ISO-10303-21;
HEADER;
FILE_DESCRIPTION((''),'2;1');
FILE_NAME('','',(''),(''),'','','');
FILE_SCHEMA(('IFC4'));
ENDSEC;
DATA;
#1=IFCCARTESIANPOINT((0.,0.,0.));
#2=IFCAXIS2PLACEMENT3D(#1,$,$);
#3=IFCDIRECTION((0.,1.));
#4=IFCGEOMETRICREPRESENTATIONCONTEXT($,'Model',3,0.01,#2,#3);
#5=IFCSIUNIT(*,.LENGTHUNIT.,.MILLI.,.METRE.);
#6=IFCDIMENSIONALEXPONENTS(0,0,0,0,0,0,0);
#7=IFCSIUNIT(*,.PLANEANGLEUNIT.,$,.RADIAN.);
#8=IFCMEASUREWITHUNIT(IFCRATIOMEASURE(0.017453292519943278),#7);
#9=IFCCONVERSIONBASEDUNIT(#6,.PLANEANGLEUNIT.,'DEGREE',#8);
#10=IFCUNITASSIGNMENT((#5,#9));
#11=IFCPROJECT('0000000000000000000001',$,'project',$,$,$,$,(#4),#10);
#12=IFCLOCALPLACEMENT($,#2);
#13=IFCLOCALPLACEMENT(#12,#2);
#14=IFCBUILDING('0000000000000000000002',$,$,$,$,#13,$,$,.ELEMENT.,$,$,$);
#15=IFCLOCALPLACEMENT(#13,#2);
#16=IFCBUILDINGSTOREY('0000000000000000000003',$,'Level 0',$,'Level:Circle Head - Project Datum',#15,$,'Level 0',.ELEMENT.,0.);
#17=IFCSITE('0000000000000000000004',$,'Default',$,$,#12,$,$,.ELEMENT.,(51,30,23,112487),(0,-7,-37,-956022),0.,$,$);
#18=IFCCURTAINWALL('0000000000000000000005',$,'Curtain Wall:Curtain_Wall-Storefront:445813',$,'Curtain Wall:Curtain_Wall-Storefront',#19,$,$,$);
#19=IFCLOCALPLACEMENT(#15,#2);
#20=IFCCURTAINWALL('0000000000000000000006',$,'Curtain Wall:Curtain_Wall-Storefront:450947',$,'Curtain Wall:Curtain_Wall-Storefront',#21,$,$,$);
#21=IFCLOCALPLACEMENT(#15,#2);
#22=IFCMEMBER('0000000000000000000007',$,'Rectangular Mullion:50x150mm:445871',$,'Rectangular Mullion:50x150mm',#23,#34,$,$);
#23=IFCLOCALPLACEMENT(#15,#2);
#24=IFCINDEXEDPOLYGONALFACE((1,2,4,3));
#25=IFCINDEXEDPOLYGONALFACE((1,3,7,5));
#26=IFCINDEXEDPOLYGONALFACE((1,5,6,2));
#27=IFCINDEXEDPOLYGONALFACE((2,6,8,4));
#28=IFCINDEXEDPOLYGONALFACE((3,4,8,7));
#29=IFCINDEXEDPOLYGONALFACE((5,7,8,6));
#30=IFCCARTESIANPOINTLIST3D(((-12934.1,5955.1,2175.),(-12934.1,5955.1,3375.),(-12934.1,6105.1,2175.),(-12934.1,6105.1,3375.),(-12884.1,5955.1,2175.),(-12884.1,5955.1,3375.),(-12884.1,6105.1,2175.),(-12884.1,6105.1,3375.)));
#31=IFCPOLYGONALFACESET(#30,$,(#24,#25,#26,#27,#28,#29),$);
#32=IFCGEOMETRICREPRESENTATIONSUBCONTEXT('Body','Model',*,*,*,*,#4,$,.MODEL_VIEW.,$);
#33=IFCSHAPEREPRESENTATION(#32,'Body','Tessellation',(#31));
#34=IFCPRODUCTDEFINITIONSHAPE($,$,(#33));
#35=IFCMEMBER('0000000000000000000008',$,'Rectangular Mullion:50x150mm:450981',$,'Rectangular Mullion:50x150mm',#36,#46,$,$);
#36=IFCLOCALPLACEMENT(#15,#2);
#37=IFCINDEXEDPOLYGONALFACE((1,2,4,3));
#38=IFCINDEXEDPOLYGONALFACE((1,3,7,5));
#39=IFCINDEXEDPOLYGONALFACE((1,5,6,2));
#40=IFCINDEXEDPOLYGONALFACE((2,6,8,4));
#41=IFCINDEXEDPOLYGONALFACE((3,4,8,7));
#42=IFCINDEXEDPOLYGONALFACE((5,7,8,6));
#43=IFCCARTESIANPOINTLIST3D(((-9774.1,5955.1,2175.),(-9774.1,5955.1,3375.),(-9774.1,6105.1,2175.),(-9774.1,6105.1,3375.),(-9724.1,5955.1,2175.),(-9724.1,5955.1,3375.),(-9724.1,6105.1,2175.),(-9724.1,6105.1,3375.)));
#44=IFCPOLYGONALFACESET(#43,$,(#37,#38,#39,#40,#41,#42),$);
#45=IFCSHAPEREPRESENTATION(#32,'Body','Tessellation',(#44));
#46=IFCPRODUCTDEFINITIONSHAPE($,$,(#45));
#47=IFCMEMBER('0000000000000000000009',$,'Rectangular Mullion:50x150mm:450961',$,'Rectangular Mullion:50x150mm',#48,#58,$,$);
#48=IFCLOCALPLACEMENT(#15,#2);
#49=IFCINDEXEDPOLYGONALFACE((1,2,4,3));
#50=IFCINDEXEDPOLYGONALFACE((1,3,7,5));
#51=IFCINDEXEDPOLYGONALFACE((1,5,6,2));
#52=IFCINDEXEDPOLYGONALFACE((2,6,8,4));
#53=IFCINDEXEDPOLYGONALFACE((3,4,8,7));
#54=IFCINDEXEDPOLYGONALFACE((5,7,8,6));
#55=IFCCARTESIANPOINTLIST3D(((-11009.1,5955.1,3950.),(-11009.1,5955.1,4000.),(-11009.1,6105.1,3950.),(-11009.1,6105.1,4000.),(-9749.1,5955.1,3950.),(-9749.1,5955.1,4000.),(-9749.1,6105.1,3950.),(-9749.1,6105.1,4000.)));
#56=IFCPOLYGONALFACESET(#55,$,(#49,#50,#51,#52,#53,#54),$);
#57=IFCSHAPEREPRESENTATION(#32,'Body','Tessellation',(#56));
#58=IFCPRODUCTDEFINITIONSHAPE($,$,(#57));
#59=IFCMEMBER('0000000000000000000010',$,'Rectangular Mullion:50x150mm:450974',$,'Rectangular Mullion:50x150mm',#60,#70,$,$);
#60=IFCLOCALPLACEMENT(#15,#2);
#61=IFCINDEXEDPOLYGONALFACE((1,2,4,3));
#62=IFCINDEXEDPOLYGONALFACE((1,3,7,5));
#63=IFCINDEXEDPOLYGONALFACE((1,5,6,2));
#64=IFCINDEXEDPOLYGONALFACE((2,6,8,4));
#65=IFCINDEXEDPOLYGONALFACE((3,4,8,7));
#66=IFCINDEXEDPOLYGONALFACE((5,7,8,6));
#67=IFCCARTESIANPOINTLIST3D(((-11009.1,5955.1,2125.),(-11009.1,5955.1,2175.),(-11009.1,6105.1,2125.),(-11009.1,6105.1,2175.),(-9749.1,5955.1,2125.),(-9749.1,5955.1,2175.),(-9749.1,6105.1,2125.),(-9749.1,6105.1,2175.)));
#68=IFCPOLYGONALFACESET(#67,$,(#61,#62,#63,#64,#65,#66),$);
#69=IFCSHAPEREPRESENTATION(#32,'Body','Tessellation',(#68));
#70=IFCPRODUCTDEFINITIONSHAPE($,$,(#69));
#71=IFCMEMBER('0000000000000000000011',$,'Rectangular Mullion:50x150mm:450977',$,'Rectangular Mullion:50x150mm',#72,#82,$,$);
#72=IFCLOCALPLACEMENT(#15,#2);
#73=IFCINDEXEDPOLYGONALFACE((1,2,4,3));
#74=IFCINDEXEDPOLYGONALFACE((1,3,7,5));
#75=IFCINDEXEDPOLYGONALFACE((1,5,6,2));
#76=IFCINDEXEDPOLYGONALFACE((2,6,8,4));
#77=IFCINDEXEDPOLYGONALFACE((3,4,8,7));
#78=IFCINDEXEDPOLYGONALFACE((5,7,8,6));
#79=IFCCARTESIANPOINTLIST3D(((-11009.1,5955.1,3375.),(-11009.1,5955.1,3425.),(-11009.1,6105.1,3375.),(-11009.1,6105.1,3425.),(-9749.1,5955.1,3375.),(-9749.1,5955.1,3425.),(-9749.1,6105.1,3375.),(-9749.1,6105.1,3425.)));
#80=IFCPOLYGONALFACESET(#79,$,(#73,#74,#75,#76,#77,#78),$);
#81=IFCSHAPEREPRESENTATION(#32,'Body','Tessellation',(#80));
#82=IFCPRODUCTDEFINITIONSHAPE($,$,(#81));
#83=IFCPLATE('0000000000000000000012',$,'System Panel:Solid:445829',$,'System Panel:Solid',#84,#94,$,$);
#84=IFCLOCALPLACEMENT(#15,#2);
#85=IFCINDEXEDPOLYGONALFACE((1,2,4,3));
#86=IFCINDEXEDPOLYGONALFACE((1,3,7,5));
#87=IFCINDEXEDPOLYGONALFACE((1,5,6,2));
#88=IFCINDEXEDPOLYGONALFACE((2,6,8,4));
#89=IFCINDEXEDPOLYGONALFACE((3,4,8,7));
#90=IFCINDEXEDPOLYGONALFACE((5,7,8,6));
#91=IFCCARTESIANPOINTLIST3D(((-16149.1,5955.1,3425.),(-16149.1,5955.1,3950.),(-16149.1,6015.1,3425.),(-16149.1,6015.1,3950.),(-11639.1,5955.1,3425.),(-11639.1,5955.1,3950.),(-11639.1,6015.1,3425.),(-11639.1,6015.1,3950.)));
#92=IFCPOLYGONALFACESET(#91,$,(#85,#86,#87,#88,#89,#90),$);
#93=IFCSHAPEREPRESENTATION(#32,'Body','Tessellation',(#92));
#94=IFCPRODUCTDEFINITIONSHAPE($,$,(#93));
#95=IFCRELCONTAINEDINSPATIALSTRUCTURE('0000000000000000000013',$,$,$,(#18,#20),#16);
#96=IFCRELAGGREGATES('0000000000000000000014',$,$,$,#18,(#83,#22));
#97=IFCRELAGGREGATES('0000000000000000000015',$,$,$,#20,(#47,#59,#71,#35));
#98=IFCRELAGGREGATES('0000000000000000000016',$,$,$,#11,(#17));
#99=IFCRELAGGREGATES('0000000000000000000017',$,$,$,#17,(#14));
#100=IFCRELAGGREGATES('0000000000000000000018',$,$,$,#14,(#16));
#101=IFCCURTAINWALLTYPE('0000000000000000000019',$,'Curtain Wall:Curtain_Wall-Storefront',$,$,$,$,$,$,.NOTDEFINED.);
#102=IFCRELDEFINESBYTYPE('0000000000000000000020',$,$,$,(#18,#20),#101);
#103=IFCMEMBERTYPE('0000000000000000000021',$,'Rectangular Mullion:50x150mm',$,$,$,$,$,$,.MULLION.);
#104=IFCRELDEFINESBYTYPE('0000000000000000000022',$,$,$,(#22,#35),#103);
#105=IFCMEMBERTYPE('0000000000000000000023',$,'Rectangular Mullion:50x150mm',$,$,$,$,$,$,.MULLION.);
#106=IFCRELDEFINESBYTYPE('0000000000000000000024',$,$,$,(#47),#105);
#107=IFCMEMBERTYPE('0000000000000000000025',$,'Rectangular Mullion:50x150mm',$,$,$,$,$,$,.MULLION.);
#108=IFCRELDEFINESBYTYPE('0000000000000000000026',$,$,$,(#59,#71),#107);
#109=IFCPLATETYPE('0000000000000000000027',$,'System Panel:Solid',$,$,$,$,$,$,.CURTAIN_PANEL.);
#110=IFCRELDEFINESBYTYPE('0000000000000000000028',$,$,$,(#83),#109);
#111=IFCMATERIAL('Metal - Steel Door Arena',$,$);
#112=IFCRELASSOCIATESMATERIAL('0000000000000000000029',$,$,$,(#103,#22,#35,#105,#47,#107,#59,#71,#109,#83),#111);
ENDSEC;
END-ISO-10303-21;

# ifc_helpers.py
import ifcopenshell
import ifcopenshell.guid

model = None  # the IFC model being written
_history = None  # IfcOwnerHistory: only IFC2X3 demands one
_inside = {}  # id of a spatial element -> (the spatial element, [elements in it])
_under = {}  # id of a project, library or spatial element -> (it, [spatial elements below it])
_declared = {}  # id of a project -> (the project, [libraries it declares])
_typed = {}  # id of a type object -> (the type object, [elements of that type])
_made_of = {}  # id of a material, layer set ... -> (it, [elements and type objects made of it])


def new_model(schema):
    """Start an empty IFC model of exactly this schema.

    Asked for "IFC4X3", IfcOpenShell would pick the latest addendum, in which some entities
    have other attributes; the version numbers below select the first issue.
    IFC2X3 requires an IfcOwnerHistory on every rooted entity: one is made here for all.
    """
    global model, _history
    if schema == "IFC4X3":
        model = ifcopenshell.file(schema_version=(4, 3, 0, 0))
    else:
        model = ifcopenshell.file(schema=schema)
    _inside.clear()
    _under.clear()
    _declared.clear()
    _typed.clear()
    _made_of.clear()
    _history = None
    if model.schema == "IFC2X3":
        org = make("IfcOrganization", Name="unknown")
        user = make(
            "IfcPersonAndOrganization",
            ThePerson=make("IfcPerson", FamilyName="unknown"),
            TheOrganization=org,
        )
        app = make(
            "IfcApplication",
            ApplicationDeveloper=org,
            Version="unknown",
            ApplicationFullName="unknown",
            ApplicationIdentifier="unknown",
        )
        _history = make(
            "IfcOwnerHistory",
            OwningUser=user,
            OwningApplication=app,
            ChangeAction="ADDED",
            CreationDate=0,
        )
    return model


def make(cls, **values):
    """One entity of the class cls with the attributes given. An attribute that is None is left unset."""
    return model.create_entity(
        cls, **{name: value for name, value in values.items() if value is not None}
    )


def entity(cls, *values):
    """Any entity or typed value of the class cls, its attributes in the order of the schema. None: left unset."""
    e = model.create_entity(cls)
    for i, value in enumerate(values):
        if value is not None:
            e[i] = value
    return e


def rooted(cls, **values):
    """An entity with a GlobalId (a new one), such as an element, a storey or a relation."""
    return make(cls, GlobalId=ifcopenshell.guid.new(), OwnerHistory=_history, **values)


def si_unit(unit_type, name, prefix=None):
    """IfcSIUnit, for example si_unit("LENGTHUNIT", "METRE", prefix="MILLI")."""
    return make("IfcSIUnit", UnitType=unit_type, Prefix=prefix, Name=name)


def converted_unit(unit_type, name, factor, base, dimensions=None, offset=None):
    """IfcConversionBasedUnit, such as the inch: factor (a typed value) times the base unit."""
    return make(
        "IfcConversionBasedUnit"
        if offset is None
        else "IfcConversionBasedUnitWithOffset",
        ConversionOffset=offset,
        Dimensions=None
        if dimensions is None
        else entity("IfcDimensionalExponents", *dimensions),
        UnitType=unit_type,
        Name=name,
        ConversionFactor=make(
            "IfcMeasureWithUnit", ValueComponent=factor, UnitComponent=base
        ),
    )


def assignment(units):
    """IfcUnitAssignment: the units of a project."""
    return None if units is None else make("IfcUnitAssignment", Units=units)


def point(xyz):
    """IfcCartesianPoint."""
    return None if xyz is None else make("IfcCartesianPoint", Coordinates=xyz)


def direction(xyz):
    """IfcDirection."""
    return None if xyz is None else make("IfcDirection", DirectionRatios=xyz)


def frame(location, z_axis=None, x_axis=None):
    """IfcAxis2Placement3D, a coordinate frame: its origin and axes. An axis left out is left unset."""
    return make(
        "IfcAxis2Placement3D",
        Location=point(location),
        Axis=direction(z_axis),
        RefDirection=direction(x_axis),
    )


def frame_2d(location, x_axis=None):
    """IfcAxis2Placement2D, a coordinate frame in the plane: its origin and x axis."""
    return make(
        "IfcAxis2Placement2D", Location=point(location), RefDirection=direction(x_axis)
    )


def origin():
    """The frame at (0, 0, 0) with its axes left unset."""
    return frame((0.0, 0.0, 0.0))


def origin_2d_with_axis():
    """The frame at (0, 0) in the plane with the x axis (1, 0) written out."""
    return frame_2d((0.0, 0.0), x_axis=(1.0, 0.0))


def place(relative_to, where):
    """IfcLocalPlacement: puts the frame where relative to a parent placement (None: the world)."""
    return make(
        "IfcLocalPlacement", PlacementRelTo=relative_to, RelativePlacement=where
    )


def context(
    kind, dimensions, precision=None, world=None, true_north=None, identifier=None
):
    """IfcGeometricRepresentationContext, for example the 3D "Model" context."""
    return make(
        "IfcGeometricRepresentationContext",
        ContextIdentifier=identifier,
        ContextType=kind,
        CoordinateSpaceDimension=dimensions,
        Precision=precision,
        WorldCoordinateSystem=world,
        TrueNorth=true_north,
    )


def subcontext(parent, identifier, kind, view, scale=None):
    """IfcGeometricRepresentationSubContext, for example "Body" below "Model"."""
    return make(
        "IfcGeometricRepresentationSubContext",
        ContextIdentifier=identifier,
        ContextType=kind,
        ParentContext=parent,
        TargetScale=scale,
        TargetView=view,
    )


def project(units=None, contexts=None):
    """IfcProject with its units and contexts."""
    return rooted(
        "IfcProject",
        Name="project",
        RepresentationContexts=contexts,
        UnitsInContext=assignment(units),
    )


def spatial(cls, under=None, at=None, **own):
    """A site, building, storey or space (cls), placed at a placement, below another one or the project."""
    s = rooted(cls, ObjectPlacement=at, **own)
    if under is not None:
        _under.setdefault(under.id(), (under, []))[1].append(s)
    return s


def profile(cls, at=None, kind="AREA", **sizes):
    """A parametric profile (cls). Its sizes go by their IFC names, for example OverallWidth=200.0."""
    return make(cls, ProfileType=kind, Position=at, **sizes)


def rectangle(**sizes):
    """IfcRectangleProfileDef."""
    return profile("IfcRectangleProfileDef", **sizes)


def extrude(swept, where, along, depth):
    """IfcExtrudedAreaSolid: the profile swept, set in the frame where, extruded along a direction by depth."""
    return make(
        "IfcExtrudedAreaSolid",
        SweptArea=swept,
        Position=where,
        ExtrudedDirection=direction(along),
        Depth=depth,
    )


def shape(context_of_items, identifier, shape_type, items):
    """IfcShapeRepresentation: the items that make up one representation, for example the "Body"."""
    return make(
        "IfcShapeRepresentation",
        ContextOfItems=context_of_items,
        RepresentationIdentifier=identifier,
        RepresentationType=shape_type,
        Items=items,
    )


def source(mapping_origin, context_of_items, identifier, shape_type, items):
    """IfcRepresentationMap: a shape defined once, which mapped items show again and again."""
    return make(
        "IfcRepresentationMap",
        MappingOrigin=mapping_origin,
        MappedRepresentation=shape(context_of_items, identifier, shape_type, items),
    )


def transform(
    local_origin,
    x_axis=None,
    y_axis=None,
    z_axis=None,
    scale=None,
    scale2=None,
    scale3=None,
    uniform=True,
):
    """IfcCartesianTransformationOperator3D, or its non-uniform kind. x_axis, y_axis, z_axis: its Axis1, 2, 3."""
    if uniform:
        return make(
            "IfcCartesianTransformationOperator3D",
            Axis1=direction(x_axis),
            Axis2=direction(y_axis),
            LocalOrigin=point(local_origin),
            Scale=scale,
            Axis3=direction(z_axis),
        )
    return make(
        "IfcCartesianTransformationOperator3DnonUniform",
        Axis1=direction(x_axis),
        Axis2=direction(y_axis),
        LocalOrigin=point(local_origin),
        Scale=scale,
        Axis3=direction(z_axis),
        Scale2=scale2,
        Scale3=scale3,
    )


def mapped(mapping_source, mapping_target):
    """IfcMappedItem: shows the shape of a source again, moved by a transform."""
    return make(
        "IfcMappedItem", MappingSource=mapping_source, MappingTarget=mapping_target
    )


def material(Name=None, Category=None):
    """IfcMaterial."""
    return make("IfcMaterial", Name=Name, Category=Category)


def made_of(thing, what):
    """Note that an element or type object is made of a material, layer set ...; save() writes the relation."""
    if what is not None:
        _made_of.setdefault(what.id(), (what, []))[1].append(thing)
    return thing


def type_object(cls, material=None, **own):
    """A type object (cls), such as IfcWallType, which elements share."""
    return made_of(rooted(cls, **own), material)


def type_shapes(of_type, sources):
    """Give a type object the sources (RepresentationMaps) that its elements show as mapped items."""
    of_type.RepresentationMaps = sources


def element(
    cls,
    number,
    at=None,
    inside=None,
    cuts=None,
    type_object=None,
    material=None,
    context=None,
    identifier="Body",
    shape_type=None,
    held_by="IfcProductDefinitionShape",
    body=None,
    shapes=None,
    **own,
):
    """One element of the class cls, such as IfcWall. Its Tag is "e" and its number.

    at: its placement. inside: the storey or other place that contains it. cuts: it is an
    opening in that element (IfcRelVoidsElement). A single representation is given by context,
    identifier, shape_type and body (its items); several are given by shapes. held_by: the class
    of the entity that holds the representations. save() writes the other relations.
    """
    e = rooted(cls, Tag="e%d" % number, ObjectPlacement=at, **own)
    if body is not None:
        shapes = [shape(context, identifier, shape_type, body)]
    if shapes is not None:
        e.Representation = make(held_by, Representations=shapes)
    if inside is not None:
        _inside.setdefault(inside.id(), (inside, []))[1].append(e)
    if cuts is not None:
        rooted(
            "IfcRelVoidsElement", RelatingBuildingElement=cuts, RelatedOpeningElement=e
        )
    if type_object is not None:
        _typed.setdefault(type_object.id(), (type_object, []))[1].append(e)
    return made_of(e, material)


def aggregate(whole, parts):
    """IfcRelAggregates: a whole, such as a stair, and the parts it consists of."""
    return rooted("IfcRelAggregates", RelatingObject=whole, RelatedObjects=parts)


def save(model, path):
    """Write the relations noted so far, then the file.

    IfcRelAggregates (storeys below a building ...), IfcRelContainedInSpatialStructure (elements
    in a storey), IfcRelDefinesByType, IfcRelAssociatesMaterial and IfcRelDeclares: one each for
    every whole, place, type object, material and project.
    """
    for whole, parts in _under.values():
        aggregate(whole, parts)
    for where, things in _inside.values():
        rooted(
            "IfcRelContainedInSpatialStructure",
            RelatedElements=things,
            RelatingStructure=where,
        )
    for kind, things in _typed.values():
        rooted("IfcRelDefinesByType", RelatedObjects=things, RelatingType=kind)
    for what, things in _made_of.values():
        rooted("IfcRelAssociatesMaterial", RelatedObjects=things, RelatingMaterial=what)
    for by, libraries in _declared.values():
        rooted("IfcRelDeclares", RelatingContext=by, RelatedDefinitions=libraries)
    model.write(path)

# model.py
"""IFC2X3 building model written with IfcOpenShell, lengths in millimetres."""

from ifc_helpers import new_model, entity, si_unit, converted_unit, direction, frame, frame_2d, origin, origin_2d_with_axis, place, context, subcontext, project, spatial, rectangle, extrude, source, transform, mapped, material, type_object, type_shapes, element, aggregate, save


model = new_model("IFC2X3")

# Units and contexts
model_context = context("Model", 3, precision=0.01, world=origin(), true_north=direction((0.0, 1.0)))
body_context = subcontext(model_context, "Body", "Model", "MODEL_VIEW")
ifc_project = project(units=[si_unit("LENGTHUNIT", "METRE", prefix="MILLI"), converted_unit("PLANEANGLEUNIT", "DEGREE", entity("IfcRatioMeasure", 0.017453292519943278), si_unit("PLANEANGLEUNIT", "RADIAN"), dimensions=[0, 0, 0, 0, 0, 0, 0])], contexts=[model_context])

# Site, building, storey
site_placement = place(None, origin())
site = spatial("IfcSite", under=ifc_project, at=site_placement, Name="Default", CompositionType="ELEMENT", RefLatitude=(51, 30, 23, 112487), RefLongitude=(0, -7, -37, -956022), RefElevation=0.0)
building_placement = place(site_placement, origin())
building = spatial("IfcBuilding", under=site, at=building_placement, CompositionType="ELEMENT")
storey_placement = place(building_placement, origin())
storey = spatial("IfcBuildingStorey", under=building, at=storey_placement, Name="Level 0", ObjectType="Level:Circle Head - Project Datum", LongName="Level 0", CompositionType="ELEMENT", Elevation=0.0)

# Curtain walls
curtain_wall_type = type_object("IfcCurtainWallType", Name="Curtain Wall:Curtain_Wall-Storefront", PredefinedType="NOTDEFINED")
curtain_wall_1_placement = place(storey_placement, origin())
curtain_wall_1 = element("IfcCurtainWall", 1, at=curtain_wall_1_placement, inside=storey, type_object=curtain_wall_type, Name="Curtain Wall:Curtain_Wall-Storefront:445813", ObjectType="Curtain Wall:Curtain_Wall-Storefront")
ifc_material_1 = material(Name="Metal - Steel Door Arena")
curtain_wall_2_placement = place(storey_placement, origin())
curtain_wall_2 = element("IfcCurtainWall", 2, at=curtain_wall_2_placement, inside=storey, type_object=curtain_wall_type, Name="Curtain Wall:Curtain_Wall-Storefront:450947", ObjectType="Curtain Wall:Curtain_Wall-Storefront")

# Members
member_type_1 = type_object("IfcMemberType", Name="Rectangular Mullion:50x150mm", PredefinedType="MULLION", material=ifc_material_1)
shared_shape_1 = source(origin(), body_context, "Body", "SweptSolid", [
    extrude(rectangle(XDim=150.0, YDim=50.0, at=origin_2d_with_axis()), frame((0.0, 0.0, -1200.0), z_axis=(0.0, 0.0, 1.0), x_axis=(0.0, -1.0, 0.0)), (0.0, 0.0, 1.0), 1200.0),
])
type_shapes(member_type_1, [shared_shape_1])
member_1_placement = place(curtain_wall_1_placement, frame((-12909.1, 6030.1, 2175.0), z_axis=(0.0, 0.0, -1.0), x_axis=(-1.0, 0.0, 0.0)))
member_1 = element("IfcMember", 3, at=member_1_placement, type_object=member_type_1, material=ifc_material_1, Name="Rectangular Mullion:50x150mm:445871", ObjectType="Rectangular Mullion:50x150mm", context=body_context, shape_type="MappedRepresentation", body=[
    mapped(shared_shape_1, transform((0.0, 0.0, 0.0), scale=1.0)),
])
member_2_placement = place(curtain_wall_2_placement, frame((-9749.1, 6030.1, 2175.0), z_axis=(0.0, 0.0, -1.0), x_axis=(-1.0, 0.0, 0.0)))
member_2 = element("IfcMember", 4, at=member_2_placement, type_object=member_type_1, material=ifc_material_1, Name="Rectangular Mullion:50x150mm:450981", ObjectType="Rectangular Mullion:50x150mm", context=body_context, shape_type="MappedRepresentation", body=[
    mapped(shared_shape_1, transform((0.0, 0.0, 0.0), scale=1.0)),
])
member_type_2 = type_object("IfcMemberType", Name="Rectangular Mullion:50x150mm", PredefinedType="MULLION", material=ifc_material_1)
shared_shape_2 = source(origin(), body_context, "Body", "SweptSolid", [
    extrude(rectangle(XDim=150.0, YDim=50.0, at=origin_2d_with_axis()), frame((-25.0, 0.0, -1260.0), z_axis=(0.0, 0.0, 1.0), x_axis=(0.0, -1.0, 0.0)), (0.0, 0.0, 1.0), 1260.0),
])
type_shapes(member_type_2, [shared_shape_2])
member_3_placement = place(curtain_wall_2_placement, frame((-11009.1, 6030.1, 4000.0), z_axis=(-1.0, 0.0, 0.0), x_axis=(0.0, 0.0, 1.0)))
member_3 = element("IfcMember", 5, at=member_3_placement, type_object=member_type_2, material=ifc_material_1, Name="Rectangular Mullion:50x150mm:450961", ObjectType="Rectangular Mullion:50x150mm", context=body_context, shape_type="MappedRepresentation", body=[
    mapped(shared_shape_2, transform((0.0, 0.0, 0.0), scale=1.0)),
])
member_type_3 = type_object("IfcMemberType", Name="Rectangular Mullion:50x150mm", PredefinedType="MULLION", material=ifc_material_1)
shared_shape_3 = source(origin(), body_context, "Body", "SweptSolid", [
    extrude(rectangle(XDim=150.0, YDim=50.0, at=origin_2d_with_axis()), frame((0.0, 0.0, -1260.0), z_axis=(0.0, 0.0, 1.0), x_axis=(0.0, -1.0, 0.0)), (0.0, 0.0, 1.0), 1260.0),
])
type_shapes(member_type_3, [shared_shape_3])
member_4_placement = place(curtain_wall_2_placement, frame((-11009.1, 6030.1, 2150.0), z_axis=(-1.0, 0.0, 0.0), x_axis=(0.0, 0.0, 1.0)))
member_4 = element("IfcMember", 6, at=member_4_placement, type_object=member_type_3, material=ifc_material_1, Name="Rectangular Mullion:50x150mm:450974", ObjectType="Rectangular Mullion:50x150mm", context=body_context, shape_type="MappedRepresentation", body=[
    mapped(shared_shape_3, transform((0.0, 0.0, 0.0), scale=1.0)),
])
member_5_placement = place(curtain_wall_2_placement, frame((-11009.1, 6030.1, 3400.0), z_axis=(-1.0, 0.0, 0.0), x_axis=(0.0, 0.0, 1.0)))
member_5 = element("IfcMember", 7, at=member_5_placement, type_object=member_type_3, material=ifc_material_1, Name="Rectangular Mullion:50x150mm:450977", ObjectType="Rectangular Mullion:50x150mm", context=body_context, shape_type="MappedRepresentation", body=[
    mapped(shared_shape_3, transform((0.0, 0.0, 0.0), scale=1.0)),
])

# Plate
plate_type_1 = type_object("IfcPlateType", Name="System Panel:Solid", PredefinedType="CURTAIN_PANEL", material=ifc_material_1)
shared_shape_4 = source(origin(), body_context, "Body", "SweptSolid", [
    extrude(rectangle(XDim=525.0, YDim=4510.0, at=frame_2d((0.0, 0.0), x_axis=(1.0, 0.0))), frame((0.0, 15.0, 262.5), z_axis=(0.0, 1.0, 0.0), x_axis=(0.0, 0.0, 1.0)), (0.0, 0.0, 1.0), 60.0),
])
type_shapes(plate_type_1, [shared_shape_4])
plate_1_placement = place(curtain_wall_1_placement, frame((-13894.1, 6030.1, 3425.0), z_axis=(0.0, 0.0, 1.0), x_axis=(-1.0, 0.0, 0.0)))
plate_1 = element("IfcPlate", 8, at=plate_1_placement, type_object=plate_type_1, material=ifc_material_1, Name="System Panel:Solid:445829", ObjectType="System Panel:Solid", context=body_context, shape_type="MappedRepresentation", body=[
    mapped(shared_shape_4, transform((0.0, 0.0, 0.0), scale=1.0)),
])
aggregate(curtain_wall_1, [plate_1, member_1])
aggregate(curtain_wall_2, [member_3, member_4, member_5, member_2])

save(model, "model.ifc")
